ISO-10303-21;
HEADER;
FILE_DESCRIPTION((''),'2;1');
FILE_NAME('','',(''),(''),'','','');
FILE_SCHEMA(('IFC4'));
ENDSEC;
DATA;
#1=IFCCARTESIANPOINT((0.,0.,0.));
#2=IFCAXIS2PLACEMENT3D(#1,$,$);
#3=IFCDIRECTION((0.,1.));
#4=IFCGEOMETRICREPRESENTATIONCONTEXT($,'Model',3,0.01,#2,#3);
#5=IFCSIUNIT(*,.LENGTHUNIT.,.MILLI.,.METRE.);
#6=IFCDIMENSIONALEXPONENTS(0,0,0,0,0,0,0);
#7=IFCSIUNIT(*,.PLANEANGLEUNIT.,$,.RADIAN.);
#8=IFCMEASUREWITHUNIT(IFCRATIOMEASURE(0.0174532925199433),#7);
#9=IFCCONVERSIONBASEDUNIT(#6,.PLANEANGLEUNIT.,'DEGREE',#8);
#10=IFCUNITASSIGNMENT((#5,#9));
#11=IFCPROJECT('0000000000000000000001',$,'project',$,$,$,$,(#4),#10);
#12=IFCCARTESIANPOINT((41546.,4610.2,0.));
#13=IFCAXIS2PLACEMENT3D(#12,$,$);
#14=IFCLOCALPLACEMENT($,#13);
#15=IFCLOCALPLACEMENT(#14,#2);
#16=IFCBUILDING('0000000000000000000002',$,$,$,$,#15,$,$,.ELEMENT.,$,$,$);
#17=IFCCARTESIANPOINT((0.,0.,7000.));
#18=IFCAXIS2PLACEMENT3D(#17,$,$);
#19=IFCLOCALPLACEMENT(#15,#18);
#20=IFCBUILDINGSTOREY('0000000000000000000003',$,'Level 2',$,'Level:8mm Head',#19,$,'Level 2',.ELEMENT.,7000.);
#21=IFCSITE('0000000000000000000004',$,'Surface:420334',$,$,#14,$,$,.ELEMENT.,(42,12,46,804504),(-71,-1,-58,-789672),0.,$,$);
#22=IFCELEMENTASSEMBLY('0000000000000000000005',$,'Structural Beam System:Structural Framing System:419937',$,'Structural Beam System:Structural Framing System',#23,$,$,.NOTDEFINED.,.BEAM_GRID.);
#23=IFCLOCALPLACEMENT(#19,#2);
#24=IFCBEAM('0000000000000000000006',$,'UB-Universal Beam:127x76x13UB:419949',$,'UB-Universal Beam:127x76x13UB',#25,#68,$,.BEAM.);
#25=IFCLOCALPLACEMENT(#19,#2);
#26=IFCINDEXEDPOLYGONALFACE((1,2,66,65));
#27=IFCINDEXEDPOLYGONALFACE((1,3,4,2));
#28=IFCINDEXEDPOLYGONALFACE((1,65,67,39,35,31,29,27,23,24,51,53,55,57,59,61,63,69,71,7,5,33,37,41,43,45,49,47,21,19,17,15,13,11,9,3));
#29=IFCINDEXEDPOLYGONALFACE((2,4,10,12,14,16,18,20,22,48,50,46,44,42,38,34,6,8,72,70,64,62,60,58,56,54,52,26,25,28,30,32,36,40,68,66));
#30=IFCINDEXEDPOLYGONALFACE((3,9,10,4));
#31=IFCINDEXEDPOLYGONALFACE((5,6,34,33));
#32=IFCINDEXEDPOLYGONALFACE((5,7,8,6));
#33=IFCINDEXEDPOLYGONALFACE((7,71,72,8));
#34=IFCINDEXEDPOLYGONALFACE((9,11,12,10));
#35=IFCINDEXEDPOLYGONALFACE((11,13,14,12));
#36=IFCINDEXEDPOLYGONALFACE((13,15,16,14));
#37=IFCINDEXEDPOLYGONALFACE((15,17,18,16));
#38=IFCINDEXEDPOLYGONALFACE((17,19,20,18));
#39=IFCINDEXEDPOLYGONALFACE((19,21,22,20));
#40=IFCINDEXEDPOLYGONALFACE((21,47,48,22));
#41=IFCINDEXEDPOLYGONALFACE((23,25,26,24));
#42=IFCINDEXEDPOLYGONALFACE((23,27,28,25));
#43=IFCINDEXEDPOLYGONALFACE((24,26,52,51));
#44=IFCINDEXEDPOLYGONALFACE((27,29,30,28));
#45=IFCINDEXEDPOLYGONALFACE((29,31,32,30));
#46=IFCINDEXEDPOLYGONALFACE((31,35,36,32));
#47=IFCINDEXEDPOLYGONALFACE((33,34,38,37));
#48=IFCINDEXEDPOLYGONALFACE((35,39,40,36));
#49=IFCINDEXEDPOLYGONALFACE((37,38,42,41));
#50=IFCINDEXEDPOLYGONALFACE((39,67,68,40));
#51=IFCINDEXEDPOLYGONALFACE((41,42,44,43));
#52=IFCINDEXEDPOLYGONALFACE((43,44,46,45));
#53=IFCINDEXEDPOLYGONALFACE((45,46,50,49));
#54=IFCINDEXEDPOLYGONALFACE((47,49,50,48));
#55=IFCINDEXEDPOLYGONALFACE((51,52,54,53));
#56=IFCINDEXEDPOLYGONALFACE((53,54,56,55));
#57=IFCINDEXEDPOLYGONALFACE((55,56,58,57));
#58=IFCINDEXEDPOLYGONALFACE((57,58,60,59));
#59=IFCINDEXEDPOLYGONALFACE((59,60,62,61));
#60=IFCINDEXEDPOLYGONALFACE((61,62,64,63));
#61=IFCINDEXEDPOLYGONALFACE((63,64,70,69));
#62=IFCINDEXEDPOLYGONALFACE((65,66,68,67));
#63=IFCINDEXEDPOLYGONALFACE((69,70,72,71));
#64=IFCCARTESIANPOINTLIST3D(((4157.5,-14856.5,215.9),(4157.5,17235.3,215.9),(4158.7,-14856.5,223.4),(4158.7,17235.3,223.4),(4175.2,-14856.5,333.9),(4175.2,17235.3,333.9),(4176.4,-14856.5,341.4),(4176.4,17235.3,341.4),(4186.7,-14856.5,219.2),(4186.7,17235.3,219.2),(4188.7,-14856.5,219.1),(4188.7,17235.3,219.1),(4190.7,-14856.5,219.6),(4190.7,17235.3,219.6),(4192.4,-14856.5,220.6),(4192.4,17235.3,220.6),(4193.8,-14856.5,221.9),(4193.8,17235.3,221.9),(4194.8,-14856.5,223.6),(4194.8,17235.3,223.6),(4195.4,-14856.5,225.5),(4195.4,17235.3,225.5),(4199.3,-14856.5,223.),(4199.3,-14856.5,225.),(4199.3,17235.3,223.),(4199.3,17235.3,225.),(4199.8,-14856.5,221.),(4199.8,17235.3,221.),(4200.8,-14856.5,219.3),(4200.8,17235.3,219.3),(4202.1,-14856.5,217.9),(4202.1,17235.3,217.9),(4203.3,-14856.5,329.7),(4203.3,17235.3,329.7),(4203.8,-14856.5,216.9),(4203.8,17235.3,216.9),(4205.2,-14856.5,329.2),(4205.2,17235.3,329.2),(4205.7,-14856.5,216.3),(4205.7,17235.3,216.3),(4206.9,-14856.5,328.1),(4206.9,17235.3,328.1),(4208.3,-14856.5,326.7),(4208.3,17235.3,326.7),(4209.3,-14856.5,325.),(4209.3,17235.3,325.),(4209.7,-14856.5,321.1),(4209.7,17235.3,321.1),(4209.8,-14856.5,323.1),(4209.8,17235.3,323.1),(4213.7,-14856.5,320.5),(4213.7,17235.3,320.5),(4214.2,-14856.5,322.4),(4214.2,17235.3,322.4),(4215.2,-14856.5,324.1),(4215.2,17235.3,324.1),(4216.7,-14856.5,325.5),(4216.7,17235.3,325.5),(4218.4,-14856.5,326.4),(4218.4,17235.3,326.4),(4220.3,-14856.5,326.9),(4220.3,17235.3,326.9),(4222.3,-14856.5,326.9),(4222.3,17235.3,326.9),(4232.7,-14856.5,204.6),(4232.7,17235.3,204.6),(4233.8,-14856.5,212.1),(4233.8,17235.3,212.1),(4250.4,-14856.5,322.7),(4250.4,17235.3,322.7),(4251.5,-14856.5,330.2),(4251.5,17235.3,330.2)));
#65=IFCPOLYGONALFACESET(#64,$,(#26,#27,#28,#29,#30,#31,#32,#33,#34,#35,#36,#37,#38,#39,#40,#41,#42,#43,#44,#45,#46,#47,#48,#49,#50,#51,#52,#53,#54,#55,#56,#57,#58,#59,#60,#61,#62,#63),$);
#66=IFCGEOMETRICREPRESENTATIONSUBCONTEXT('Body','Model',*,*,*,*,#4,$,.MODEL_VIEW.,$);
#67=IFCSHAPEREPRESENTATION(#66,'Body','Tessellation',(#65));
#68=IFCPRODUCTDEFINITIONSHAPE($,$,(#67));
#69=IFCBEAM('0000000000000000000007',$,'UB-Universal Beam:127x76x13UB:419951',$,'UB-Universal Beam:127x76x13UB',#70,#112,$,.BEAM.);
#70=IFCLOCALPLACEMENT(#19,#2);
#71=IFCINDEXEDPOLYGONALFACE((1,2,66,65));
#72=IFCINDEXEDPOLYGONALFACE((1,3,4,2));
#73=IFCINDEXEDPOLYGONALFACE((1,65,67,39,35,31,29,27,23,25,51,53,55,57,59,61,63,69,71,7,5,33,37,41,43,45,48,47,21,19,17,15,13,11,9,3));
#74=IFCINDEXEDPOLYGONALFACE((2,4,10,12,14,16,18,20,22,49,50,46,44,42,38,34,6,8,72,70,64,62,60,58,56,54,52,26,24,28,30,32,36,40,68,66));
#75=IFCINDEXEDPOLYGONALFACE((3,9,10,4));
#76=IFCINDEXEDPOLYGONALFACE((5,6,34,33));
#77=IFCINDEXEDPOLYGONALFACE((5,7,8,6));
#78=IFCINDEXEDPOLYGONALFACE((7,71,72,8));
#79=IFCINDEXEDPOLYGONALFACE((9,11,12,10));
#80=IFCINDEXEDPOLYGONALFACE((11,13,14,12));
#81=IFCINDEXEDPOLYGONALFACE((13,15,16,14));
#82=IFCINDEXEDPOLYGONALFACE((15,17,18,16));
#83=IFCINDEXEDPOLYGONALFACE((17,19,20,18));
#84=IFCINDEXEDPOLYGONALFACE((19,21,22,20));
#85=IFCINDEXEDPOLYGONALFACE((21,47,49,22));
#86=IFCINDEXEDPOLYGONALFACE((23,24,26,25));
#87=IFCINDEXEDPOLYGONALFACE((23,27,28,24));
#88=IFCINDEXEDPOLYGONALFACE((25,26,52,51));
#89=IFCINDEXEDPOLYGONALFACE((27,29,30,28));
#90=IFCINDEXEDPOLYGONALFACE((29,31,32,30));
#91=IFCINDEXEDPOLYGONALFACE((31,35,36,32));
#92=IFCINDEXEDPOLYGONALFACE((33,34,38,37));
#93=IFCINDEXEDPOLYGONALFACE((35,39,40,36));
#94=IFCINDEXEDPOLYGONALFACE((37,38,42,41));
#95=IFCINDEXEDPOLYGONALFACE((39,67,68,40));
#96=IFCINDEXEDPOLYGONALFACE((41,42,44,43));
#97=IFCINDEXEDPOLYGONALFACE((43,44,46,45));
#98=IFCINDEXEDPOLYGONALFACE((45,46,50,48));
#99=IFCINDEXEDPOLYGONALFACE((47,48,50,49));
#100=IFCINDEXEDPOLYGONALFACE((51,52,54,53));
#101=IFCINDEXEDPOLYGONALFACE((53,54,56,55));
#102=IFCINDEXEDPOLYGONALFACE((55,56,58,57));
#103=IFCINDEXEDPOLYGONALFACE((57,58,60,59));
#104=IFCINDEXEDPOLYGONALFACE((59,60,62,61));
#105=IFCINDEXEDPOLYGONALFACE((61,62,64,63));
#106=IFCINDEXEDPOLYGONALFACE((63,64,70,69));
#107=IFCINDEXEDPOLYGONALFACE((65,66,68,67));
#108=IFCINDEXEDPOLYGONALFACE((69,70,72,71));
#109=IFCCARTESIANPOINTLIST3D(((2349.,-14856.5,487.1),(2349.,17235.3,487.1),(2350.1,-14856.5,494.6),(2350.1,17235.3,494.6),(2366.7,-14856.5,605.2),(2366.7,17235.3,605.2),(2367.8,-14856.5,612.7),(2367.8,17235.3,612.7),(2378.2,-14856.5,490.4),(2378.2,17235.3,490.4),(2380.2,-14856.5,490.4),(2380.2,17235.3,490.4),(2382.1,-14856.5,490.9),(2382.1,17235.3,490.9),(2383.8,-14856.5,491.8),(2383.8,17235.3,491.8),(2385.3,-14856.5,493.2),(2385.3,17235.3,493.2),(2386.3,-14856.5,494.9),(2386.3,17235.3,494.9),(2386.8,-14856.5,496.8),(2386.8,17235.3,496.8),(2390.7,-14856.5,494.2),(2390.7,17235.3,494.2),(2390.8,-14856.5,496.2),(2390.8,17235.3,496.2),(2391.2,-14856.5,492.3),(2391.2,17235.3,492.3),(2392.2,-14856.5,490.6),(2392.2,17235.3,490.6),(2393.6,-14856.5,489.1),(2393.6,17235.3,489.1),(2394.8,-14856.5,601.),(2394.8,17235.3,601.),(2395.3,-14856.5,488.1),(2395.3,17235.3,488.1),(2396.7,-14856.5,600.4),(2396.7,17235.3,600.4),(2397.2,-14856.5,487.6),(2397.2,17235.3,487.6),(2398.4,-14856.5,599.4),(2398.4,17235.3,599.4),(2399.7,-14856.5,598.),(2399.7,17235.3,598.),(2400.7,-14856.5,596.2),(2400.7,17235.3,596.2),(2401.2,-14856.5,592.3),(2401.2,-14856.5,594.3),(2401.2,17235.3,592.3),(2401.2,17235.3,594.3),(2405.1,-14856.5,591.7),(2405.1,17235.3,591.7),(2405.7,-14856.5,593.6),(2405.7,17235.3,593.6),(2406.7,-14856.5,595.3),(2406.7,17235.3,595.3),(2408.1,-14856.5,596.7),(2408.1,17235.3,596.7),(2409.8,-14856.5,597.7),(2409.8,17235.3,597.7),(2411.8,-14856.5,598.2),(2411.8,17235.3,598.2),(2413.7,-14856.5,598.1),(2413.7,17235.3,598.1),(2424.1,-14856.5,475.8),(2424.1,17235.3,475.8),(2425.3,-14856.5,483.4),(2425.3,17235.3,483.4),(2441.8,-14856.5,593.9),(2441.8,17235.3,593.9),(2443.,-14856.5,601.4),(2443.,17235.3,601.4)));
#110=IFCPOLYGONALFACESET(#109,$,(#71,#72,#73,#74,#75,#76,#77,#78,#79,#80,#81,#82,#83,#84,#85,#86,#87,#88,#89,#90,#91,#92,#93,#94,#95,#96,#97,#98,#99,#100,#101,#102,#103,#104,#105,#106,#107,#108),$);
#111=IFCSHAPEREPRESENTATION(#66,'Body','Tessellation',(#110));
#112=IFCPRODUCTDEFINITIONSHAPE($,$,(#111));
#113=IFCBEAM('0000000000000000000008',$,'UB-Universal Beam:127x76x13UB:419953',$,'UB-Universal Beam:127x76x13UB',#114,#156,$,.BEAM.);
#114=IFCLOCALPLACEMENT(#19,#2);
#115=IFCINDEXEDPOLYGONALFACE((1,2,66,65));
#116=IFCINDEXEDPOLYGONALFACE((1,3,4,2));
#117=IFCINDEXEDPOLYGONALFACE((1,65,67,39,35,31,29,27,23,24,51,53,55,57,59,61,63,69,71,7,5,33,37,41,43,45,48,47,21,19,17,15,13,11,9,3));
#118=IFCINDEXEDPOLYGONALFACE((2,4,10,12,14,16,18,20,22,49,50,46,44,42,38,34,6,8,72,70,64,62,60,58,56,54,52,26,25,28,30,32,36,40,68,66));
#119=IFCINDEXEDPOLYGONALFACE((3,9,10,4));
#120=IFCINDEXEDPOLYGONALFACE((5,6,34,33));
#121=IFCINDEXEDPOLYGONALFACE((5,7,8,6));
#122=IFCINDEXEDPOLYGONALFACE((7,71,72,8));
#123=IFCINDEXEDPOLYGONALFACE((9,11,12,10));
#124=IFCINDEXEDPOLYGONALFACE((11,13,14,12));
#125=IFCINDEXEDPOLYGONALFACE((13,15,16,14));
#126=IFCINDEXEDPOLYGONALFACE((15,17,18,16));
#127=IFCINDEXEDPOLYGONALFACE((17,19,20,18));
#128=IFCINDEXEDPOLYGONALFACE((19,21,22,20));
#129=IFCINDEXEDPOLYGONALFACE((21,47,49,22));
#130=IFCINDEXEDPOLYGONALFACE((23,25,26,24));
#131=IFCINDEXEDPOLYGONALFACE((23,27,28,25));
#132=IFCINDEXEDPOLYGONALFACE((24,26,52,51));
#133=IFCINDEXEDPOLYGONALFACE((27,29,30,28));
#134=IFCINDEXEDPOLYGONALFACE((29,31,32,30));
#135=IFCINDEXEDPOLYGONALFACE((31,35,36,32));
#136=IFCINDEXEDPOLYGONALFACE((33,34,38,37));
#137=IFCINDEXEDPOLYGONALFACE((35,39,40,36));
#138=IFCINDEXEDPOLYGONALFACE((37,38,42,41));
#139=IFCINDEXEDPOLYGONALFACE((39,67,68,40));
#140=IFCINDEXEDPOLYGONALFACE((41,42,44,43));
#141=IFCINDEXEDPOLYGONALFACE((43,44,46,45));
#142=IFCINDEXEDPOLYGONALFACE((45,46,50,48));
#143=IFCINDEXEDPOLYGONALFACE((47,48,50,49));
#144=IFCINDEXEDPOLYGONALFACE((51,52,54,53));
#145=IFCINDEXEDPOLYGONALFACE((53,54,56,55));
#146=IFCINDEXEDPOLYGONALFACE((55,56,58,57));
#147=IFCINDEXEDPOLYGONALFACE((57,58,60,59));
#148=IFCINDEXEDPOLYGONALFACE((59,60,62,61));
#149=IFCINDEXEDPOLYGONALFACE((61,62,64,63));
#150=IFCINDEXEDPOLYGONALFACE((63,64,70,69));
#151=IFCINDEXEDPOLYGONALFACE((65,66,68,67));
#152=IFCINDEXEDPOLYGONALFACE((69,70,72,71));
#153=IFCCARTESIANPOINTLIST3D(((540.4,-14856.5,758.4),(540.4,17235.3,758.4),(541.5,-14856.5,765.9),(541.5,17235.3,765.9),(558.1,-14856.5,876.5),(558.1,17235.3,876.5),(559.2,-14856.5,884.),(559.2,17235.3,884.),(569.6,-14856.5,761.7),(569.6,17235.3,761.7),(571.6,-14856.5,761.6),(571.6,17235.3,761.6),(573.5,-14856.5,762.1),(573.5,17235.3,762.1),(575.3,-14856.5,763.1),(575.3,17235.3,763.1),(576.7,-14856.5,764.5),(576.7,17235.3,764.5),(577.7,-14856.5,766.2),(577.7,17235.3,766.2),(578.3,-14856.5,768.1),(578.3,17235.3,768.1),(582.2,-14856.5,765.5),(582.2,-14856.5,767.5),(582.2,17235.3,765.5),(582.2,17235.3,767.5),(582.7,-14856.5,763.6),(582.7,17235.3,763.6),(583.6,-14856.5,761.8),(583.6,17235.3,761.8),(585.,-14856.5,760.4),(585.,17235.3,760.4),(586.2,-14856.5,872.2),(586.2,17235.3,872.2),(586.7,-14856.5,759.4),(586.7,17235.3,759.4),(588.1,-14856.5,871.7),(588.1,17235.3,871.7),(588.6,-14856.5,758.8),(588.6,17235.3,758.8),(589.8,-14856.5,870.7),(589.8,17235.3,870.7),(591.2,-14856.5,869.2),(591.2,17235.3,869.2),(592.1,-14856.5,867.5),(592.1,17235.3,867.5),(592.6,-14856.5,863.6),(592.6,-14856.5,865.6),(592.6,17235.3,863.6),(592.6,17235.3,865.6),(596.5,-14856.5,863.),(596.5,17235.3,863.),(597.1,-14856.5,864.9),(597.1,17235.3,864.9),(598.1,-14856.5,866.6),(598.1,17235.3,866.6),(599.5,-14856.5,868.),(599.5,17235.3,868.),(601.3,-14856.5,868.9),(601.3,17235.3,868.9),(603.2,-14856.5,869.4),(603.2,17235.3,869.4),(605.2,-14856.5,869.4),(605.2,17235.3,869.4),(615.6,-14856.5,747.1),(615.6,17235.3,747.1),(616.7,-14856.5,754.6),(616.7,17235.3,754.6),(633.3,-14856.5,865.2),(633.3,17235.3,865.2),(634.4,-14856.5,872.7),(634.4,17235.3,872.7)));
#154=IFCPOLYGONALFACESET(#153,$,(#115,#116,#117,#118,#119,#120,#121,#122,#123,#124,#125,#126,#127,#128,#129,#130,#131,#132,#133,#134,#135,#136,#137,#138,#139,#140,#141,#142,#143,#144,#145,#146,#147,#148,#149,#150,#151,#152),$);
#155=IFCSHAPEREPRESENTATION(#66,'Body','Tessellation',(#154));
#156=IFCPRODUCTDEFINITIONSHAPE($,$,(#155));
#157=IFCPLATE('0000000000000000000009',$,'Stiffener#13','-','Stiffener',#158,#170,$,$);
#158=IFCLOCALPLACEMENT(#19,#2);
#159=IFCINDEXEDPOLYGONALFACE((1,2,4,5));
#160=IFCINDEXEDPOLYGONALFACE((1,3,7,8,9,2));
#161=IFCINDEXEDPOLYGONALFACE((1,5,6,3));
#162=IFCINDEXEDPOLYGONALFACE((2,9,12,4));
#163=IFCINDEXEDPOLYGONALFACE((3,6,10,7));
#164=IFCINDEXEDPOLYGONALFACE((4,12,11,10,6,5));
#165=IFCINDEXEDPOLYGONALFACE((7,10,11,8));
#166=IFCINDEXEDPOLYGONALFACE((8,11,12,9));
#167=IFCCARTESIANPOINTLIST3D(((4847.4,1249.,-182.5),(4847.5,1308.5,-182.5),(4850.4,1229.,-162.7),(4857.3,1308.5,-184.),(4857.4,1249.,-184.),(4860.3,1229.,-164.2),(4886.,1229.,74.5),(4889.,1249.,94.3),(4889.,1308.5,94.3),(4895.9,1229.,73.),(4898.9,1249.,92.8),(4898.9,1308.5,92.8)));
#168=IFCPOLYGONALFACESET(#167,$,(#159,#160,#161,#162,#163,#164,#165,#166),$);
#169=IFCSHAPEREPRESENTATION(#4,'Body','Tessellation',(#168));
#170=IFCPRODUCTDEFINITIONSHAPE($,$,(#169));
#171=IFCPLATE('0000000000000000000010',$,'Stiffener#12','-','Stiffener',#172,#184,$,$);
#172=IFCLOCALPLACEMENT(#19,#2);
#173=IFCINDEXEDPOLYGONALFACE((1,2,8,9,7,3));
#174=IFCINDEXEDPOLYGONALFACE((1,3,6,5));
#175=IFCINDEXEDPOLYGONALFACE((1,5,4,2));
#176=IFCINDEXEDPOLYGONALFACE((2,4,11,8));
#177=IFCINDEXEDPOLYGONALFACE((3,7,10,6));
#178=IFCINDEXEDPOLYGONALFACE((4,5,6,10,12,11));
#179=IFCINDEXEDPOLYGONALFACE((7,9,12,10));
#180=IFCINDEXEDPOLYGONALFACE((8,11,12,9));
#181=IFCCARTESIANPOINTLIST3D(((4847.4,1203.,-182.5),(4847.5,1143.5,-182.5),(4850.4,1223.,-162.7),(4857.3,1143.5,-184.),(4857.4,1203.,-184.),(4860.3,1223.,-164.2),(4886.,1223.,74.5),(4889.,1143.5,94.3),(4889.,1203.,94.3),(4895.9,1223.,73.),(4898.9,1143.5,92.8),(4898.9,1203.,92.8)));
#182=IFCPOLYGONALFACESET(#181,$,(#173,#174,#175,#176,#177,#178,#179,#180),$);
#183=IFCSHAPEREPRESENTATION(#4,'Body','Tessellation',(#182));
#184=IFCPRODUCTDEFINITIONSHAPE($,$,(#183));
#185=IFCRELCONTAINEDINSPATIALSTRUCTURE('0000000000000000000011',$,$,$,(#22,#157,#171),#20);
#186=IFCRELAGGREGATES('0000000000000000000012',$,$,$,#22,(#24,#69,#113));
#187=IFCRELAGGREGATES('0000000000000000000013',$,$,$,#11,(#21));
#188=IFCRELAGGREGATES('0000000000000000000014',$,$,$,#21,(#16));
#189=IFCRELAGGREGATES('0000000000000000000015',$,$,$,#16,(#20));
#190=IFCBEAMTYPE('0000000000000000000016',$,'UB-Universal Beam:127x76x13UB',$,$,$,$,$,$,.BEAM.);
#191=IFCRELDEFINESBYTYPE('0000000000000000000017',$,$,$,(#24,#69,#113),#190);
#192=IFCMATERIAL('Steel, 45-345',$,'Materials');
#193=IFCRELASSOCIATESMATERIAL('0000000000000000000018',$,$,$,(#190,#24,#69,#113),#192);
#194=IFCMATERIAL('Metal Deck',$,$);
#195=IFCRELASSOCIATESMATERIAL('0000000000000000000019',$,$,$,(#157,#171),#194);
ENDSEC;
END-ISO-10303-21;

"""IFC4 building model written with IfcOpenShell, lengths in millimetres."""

from ifc_helpers import new_model, entity, si_unit, converted_unit, direction, frame, frame_2d, origin, origin_with_axes, place, context, subcontext, project, spatial, polyline, i_section, outline, extrude, source, transform, mapped, material, material_profile, profile_set, profile_usage, type_object, type_shapes, element, aggregate, save


model = new_model("IFC4")

# Units and contexts
model_context = context("Model", 3, precision=0.01, world=origin(), true_north=direction((0.0, 1.0)))
body_context = subcontext(model_context, "Body", "Model", "MODEL_VIEW")
ifc_project = project(units=[si_unit("LENGTHUNIT", "METRE", prefix="MILLI"), converted_unit("PLANEANGLEUNIT", "DEGREE", entity("IfcRatioMeasure", 0.0174532925199433), si_unit("PLANEANGLEUNIT", "RADIAN"), dimensions=[0, 0, 0, 0, 0, 0, 0])], contexts=[model_context])

# Site, building, storey
site_placement = place(None, frame((41546.0, 4610.2, 0.0)))
site = spatial("IfcSite", under=ifc_project, at=site_placement, Name="Surface:420334", CompositionType="ELEMENT", RefLatitude=(42, 12, 46, 804504), RefLongitude=(-71, -1, -58, -789672), RefElevation=0.0)
building_placement = place(site_placement, origin())
building = spatial("IfcBuilding", under=site, at=building_placement, CompositionType="ELEMENT")
storey_placement = place(building_placement, frame((0.0, 0.0, 7000.0)))
storey = spatial("IfcBuildingStorey", under=building, at=storey_placement, Name="Level 2", ObjectType="Level:8mm Head", LongName="Level 2", CompositionType="ELEMENT", Elevation=7000.0)

# Element assembly, beams
assembly_placement = place(storey_placement, origin())
assembly = element("IfcElementAssembly", 1, at=assembly_placement, inside=storey, Name="Structural Beam System:Structural Framing System:419937", ObjectType="Structural Beam System:Structural Framing System", AssemblyPlace="NOTDEFINED", PredefinedType="BEAM_GRID")
ifc_material_1 = material(Name="Steel, 45-345", Category="Materials")
ifc_material_profile = material_profile(ifc_material_1, i_section(OverallWidth=76.0, OverallDepth=127.0, WebThickness=4.0, FlangeThickness=7.6, FilletRadius=7.6, at=frame_2d((0.0, 0.0), x_axis=(0.0, 1.0))), Name="127x76x13UB")
ifc_profile_set = profile_set([ifc_material_profile], Name="127x76x13UB")
ifc_profile_usage_1 = profile_usage(ifc_profile_set, cardinal=8)
beam_type = type_object("IfcBeamType", Name="UB-Universal Beam:127x76x13UB", PredefinedType="BEAM", material=ifc_profile_set)
shared_shape = source(origin(), body_context, "Body", "SweptSolid", [
    extrude(i_section(OverallWidth=76.0, OverallDepth=127.0, WebThickness=4.0, FlangeThickness=7.6, FilletRadius=7.6, at=frame_2d((0.0, 0.0), x_axis=(0.0, 1.0))), frame((-15973.5, 0.0, 0.0), z_axis=(1.0, 0.0, 0.0), x_axis=(0.0, 0.0, -1.0)), (0.0, 0.0, 1.0), 32091.8),
])
type_shapes(beam_type, [shared_shape])
beam_1_placement = place(assembly_placement, frame((4204.5, 1261.8, 273.0), z_axis=(0.148327, 0.0, 0.988938), x_axis=(0.0, -1.0, 0.0)))
beam_1 = element("IfcBeam", 2, at=beam_1_placement, type_object=beam_type, material=ifc_profile_usage_1, Name="UB-Universal Beam:127x76x13UB:419949", ObjectType="UB-Universal Beam:127x76x13UB", PredefinedType="BEAM", context=body_context, shape_type="MappedRepresentation", body=[
    mapped(shared_shape, transform((0.0, 0.0, 0.0), scale=1.0)),
])
ifc_profile_usage_2 = profile_usage(ifc_profile_set, cardinal=8)
beam_2_placement = place(assembly_placement, frame((2396.0, 1261.8, 544.3), z_axis=(0.148327, 0.0, 0.988938), x_axis=(0.0, -1.0, 0.0)))
beam_2 = element("IfcBeam", 3, at=beam_2_placement, type_object=beam_type, material=ifc_profile_usage_2, Name="UB-Universal Beam:127x76x13UB:419951", ObjectType="UB-Universal Beam:127x76x13UB", PredefinedType="BEAM", context=body_context, shape_type="MappedRepresentation", body=[
    mapped(shared_shape, transform((0.0, 0.0, 0.0), scale=1.0)),
])
ifc_profile_usage_3 = profile_usage(ifc_profile_set, cardinal=8)
beam_3_placement = place(assembly_placement, frame((587.4, 1261.8, 815.5), z_axis=(0.148327, 0.0, 0.988938), x_axis=(0.0, -1.0, 0.0)))
beam_3 = element("IfcBeam", 4, at=beam_3_placement, type_object=beam_type, material=ifc_profile_usage_3, Name="UB-Universal Beam:127x76x13UB:419953", ObjectType="UB-Universal Beam:127x76x13UB", PredefinedType="BEAM", context=body_context, shape_type="MappedRepresentation", body=[
    mapped(shared_shape, transform((0.0, 0.0, 0.0), scale=1.0)),
])
aggregate(assembly, [beam_1, beam_2, beam_3])

# Plates, openings
ifc_material_2 = material(Name="Metal Deck")
plate_1_placement = place(storey_placement, frame((4857.3, 1308.5, -184.0), z_axis=(-0.988936, 0.0, 0.14834), x_axis=(0.0, -1.0, 0.0)))
plate_1 = element("IfcPlate", 5, at=plate_1_placement, inside=storey, material=ifc_material_2, Name="Stiffener#13", Description="-", ObjectType="Stiffener", context=model_context, shape_type="SweptSolid", body=[
    extrude(outline(polyline([(0.0, 0.0), (79.5, 0.0), (79.5, 279.8), (0.0, 279.8), (0.0, 0.0)])), origin_with_axes(), (0.0, 0.0, 1.0), 10.0),
])
opening_1_placement = place(plate_1_placement, frame((0.0, 0.0, 0.0), z_axis=(0.0, 0.0, 1.0), x_axis=(1.0, 0.0, 0.0)))
element("IfcOpeningElement", 6, at=opening_1_placement, cuts=plate_1, ObjectType="Opening", context=model_context, shape_type="SweptSolid", body=[
    extrude(outline(polyline([(79.5, 279.8), (59.5, 279.8), (79.5, 259.8), (79.5, 279.8)])), origin(), (0.0, 0.0, 1.0), 10.0),
])
opening_2_placement = place(plate_1_placement, frame((0.0, 0.0, 0.0), z_axis=(0.0, 0.0, 1.0), x_axis=(1.0, 0.0, 0.0)))
element("IfcOpeningElement", 7, at=opening_2_placement, cuts=plate_1, ObjectType="Opening", context=model_context, shape_type="SweptSolid", body=[
    extrude(outline(polyline([(79.5, 0.0), (79.5, 20.0), (59.5, 0.0), (79.5, 0.0)])), origin(), (0.0, 0.0, 1.0), 10.0),
])
plate_2_placement = place(storey_placement, frame((4857.3, 1223.0, -184.0), z_axis=(-0.988936, 0.0, 0.14834), x_axis=(0.0, -1.0, 0.0)))
plate_2 = element("IfcPlate", 8, at=plate_2_placement, inside=storey, material=ifc_material_2, Name="Stiffener#12", Description="-", ObjectType="Stiffener", context=model_context, shape_type="SweptSolid", body=[
    extrude(outline(polyline([(0.0, 0.0), (79.5, 0.0), (79.5, 279.8), (0.0, 279.8), (0.0, 0.0)])), origin_with_axes(), (0.0, 0.0, 1.0), 10.0),
])
opening_3_placement = place(plate_2_placement, frame((0.0, 0.0, 0.0), z_axis=(0.0, 0.0, 1.0), x_axis=(1.0, 0.0, 0.0)))
element("IfcOpeningElement", 9, at=opening_3_placement, cuts=plate_2, ObjectType="Opening", context=model_context, shape_type="SweptSolid", body=[
    extrude(outline(polyline([(0.0, 279.8), (0.0, 259.8), (20.0, 279.8), (0.0, 279.8)])), origin(), (0.0, 0.0, 1.0), 10.0),
])
opening_4_placement = place(plate_2_placement, frame((0.0, 0.0, 0.0), z_axis=(0.0, 0.0, 1.0), x_axis=(1.0, 0.0, 0.0)))
element("IfcOpeningElement", 10, at=opening_4_placement, cuts=plate_2, ObjectType="Opening", context=model_context, shape_type="SweptSolid", body=[
    extrude(outline(polyline([(0.0, 0.0), (20.0, 0.0), (0.0, 20.0), (0.0, 0.0)])), origin(), (0.0, 0.0, 1.0), 10.0),
])

save(model, "model.ifc")
